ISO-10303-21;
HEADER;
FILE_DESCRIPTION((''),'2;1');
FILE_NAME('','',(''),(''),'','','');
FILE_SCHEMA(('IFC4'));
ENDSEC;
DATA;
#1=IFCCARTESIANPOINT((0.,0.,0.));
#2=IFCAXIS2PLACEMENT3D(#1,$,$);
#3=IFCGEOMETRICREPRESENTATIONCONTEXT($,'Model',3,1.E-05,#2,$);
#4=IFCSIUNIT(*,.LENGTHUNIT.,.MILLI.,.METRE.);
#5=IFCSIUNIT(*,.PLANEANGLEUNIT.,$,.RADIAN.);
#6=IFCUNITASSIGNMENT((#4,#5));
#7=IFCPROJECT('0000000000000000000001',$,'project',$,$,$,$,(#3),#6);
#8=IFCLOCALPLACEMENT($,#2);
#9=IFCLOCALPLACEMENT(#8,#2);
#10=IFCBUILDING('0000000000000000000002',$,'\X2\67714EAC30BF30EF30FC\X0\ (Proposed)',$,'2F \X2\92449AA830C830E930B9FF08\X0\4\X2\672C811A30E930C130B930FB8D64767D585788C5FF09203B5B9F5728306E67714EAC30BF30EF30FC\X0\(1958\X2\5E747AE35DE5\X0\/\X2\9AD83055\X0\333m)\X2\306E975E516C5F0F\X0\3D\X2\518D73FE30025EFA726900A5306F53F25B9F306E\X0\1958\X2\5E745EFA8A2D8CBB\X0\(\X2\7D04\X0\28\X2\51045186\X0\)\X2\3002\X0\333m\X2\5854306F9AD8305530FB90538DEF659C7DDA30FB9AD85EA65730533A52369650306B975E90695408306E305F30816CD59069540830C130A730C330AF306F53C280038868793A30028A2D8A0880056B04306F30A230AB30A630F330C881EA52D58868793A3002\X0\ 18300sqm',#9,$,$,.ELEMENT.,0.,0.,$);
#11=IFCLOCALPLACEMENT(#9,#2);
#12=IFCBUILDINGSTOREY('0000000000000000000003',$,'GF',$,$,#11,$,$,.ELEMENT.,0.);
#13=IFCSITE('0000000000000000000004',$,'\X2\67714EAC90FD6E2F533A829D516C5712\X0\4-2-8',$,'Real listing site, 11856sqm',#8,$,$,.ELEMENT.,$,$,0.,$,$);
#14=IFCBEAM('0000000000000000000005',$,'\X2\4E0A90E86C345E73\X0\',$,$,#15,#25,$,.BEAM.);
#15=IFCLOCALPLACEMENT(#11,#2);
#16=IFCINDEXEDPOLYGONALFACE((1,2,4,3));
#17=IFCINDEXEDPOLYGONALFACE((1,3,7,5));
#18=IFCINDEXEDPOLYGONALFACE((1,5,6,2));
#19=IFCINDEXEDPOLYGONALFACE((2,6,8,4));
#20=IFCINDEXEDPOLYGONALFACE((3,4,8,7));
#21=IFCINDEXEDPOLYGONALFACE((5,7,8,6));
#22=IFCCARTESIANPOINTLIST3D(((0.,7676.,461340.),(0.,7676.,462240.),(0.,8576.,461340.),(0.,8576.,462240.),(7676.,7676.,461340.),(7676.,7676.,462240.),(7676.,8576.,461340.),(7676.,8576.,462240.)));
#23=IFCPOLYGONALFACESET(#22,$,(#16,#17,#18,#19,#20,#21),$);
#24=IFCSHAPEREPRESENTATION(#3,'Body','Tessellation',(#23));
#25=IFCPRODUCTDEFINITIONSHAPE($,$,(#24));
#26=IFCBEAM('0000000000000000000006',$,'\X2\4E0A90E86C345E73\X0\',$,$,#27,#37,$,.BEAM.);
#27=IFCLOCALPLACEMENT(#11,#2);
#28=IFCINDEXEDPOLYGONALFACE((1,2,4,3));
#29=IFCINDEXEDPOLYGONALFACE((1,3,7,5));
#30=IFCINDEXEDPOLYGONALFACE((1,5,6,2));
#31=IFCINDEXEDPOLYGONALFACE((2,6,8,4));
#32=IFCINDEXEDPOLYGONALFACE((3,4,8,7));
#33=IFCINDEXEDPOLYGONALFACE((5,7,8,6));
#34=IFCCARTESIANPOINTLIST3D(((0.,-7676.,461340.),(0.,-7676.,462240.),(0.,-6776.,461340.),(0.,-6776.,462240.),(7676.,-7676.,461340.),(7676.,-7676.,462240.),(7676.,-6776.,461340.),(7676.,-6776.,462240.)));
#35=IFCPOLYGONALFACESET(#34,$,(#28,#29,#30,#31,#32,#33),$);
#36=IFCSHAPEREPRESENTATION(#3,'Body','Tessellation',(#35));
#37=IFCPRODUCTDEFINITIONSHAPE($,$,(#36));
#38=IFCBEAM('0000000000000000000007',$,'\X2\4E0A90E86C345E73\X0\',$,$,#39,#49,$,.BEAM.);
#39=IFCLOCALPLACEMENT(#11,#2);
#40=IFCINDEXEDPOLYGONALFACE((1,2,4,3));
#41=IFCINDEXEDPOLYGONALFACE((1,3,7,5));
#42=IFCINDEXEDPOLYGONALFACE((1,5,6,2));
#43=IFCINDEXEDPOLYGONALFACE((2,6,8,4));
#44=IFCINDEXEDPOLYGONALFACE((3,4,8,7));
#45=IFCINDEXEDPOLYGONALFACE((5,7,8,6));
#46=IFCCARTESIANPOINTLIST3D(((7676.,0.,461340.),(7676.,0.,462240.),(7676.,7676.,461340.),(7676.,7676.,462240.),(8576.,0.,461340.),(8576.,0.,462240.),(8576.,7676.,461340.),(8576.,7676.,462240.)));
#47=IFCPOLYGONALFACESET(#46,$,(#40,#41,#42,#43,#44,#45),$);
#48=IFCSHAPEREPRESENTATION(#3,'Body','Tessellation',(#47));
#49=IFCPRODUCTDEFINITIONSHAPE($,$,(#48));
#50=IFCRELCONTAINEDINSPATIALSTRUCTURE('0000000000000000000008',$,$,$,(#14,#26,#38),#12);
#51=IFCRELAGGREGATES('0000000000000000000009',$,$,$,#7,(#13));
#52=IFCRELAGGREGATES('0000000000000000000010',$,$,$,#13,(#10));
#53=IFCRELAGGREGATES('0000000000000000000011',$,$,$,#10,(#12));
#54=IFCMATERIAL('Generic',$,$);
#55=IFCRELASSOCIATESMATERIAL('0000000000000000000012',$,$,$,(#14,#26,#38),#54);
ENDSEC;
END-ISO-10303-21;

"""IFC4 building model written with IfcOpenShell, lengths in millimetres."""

from ifc_helpers import new_model, si_unit, frame, frame_2d, origin, place, context, project, spatial, rectangle, extrude, material, element, save


model = new_model("IFC4")

# Units and contexts
model_context = context("Model", 3, precision=1e-05, world=origin())
ifc_project = project(units=[si_unit("LENGTHUNIT", "METRE", prefix="MILLI"), si_unit("PLANEANGLEUNIT", "RADIAN")], contexts=[model_context])

# Site, building, storey
site_placement = place(None, origin())
site = spatial("IfcSite", under=ifc_project, at=site_placement, Name="東京都港区芝公園4-2-8", ObjectType="Real listing site, 11856sqm", CompositionType="ELEMENT", RefElevation=0.0)
building_placement = place(site_placement, origin())
building = spatial("IfcBuilding", under=site, at=building_placement, Name="東京タワー (Proposed)", ObjectType="2F 鉄骨トラス（4本脚ラチス・赤白塗装）※実在の東京タワー(1958年竣工/高さ333m)の非公式3D再現。建物¥は史実の1958年建設費(約28億円)。333m塔は高さ・道路斜線・高度地区制限に非適合のため法適合チェックは参考表示。設計者欄はアカウント自動表示。 18300sqm", CompositionType="ELEMENT", ElevationOfRefHeight=0.0, ElevationOfTerrain=0.0)
storey_placement = place(building_placement, origin())
storey = spatial("IfcBuildingStorey", under=building, at=storey_placement, Name="GF", CompositionType="ELEMENT", Elevation=0.0)

# Shared definitions
ifc_material = material(Name="Generic")

# Beams
beam_1_placement = place(storey_placement, frame((0.0, 3838.0, 230670.0)))
element("IfcBeam", 1, at=beam_1_placement, inside=storey, material=ifc_material, Name="上部水平", PredefinedType="BEAM", context=model_context, shape_type="SweptSolid", body=[
    extrude(rectangle(XDim=7676.0, YDim=900.0, at=frame_2d((3838.0, 450.0))), frame((0.0, 3838.0, 230670.0)), (0.0, 0.0, 1.0), 900.0),
])
beam_2_placement = place(storey_placement, frame((0.0, -3838.0, 230670.0)))
element("IfcBeam", 2, at=beam_2_placement, inside=storey, material=ifc_material, Name="上部水平", PredefinedType="BEAM", context=model_context, shape_type="SweptSolid", body=[
    extrude(rectangle(XDim=7676.0, YDim=900.0, at=frame_2d((3838.0, 450.0))), frame((0.0, -3838.0, 230670.0)), (0.0, 0.0, 1.0), 900.0),
])
beam_3_placement = place(storey_placement, frame((3838.0, 0.0, 230670.0)))
element("IfcBeam", 3, at=beam_3_placement, inside=storey, material=ifc_material, Name="上部水平", PredefinedType="BEAM", context=model_context, shape_type="SweptSolid", body=[
    extrude(rectangle(XDim=900.0, YDim=7676.0, at=frame_2d((450.0, 3838.0))), frame((3838.0, 0.0, 230670.0)), (0.0, 0.0, 1.0), 900.0),
])

save(model, "model.ifc")
